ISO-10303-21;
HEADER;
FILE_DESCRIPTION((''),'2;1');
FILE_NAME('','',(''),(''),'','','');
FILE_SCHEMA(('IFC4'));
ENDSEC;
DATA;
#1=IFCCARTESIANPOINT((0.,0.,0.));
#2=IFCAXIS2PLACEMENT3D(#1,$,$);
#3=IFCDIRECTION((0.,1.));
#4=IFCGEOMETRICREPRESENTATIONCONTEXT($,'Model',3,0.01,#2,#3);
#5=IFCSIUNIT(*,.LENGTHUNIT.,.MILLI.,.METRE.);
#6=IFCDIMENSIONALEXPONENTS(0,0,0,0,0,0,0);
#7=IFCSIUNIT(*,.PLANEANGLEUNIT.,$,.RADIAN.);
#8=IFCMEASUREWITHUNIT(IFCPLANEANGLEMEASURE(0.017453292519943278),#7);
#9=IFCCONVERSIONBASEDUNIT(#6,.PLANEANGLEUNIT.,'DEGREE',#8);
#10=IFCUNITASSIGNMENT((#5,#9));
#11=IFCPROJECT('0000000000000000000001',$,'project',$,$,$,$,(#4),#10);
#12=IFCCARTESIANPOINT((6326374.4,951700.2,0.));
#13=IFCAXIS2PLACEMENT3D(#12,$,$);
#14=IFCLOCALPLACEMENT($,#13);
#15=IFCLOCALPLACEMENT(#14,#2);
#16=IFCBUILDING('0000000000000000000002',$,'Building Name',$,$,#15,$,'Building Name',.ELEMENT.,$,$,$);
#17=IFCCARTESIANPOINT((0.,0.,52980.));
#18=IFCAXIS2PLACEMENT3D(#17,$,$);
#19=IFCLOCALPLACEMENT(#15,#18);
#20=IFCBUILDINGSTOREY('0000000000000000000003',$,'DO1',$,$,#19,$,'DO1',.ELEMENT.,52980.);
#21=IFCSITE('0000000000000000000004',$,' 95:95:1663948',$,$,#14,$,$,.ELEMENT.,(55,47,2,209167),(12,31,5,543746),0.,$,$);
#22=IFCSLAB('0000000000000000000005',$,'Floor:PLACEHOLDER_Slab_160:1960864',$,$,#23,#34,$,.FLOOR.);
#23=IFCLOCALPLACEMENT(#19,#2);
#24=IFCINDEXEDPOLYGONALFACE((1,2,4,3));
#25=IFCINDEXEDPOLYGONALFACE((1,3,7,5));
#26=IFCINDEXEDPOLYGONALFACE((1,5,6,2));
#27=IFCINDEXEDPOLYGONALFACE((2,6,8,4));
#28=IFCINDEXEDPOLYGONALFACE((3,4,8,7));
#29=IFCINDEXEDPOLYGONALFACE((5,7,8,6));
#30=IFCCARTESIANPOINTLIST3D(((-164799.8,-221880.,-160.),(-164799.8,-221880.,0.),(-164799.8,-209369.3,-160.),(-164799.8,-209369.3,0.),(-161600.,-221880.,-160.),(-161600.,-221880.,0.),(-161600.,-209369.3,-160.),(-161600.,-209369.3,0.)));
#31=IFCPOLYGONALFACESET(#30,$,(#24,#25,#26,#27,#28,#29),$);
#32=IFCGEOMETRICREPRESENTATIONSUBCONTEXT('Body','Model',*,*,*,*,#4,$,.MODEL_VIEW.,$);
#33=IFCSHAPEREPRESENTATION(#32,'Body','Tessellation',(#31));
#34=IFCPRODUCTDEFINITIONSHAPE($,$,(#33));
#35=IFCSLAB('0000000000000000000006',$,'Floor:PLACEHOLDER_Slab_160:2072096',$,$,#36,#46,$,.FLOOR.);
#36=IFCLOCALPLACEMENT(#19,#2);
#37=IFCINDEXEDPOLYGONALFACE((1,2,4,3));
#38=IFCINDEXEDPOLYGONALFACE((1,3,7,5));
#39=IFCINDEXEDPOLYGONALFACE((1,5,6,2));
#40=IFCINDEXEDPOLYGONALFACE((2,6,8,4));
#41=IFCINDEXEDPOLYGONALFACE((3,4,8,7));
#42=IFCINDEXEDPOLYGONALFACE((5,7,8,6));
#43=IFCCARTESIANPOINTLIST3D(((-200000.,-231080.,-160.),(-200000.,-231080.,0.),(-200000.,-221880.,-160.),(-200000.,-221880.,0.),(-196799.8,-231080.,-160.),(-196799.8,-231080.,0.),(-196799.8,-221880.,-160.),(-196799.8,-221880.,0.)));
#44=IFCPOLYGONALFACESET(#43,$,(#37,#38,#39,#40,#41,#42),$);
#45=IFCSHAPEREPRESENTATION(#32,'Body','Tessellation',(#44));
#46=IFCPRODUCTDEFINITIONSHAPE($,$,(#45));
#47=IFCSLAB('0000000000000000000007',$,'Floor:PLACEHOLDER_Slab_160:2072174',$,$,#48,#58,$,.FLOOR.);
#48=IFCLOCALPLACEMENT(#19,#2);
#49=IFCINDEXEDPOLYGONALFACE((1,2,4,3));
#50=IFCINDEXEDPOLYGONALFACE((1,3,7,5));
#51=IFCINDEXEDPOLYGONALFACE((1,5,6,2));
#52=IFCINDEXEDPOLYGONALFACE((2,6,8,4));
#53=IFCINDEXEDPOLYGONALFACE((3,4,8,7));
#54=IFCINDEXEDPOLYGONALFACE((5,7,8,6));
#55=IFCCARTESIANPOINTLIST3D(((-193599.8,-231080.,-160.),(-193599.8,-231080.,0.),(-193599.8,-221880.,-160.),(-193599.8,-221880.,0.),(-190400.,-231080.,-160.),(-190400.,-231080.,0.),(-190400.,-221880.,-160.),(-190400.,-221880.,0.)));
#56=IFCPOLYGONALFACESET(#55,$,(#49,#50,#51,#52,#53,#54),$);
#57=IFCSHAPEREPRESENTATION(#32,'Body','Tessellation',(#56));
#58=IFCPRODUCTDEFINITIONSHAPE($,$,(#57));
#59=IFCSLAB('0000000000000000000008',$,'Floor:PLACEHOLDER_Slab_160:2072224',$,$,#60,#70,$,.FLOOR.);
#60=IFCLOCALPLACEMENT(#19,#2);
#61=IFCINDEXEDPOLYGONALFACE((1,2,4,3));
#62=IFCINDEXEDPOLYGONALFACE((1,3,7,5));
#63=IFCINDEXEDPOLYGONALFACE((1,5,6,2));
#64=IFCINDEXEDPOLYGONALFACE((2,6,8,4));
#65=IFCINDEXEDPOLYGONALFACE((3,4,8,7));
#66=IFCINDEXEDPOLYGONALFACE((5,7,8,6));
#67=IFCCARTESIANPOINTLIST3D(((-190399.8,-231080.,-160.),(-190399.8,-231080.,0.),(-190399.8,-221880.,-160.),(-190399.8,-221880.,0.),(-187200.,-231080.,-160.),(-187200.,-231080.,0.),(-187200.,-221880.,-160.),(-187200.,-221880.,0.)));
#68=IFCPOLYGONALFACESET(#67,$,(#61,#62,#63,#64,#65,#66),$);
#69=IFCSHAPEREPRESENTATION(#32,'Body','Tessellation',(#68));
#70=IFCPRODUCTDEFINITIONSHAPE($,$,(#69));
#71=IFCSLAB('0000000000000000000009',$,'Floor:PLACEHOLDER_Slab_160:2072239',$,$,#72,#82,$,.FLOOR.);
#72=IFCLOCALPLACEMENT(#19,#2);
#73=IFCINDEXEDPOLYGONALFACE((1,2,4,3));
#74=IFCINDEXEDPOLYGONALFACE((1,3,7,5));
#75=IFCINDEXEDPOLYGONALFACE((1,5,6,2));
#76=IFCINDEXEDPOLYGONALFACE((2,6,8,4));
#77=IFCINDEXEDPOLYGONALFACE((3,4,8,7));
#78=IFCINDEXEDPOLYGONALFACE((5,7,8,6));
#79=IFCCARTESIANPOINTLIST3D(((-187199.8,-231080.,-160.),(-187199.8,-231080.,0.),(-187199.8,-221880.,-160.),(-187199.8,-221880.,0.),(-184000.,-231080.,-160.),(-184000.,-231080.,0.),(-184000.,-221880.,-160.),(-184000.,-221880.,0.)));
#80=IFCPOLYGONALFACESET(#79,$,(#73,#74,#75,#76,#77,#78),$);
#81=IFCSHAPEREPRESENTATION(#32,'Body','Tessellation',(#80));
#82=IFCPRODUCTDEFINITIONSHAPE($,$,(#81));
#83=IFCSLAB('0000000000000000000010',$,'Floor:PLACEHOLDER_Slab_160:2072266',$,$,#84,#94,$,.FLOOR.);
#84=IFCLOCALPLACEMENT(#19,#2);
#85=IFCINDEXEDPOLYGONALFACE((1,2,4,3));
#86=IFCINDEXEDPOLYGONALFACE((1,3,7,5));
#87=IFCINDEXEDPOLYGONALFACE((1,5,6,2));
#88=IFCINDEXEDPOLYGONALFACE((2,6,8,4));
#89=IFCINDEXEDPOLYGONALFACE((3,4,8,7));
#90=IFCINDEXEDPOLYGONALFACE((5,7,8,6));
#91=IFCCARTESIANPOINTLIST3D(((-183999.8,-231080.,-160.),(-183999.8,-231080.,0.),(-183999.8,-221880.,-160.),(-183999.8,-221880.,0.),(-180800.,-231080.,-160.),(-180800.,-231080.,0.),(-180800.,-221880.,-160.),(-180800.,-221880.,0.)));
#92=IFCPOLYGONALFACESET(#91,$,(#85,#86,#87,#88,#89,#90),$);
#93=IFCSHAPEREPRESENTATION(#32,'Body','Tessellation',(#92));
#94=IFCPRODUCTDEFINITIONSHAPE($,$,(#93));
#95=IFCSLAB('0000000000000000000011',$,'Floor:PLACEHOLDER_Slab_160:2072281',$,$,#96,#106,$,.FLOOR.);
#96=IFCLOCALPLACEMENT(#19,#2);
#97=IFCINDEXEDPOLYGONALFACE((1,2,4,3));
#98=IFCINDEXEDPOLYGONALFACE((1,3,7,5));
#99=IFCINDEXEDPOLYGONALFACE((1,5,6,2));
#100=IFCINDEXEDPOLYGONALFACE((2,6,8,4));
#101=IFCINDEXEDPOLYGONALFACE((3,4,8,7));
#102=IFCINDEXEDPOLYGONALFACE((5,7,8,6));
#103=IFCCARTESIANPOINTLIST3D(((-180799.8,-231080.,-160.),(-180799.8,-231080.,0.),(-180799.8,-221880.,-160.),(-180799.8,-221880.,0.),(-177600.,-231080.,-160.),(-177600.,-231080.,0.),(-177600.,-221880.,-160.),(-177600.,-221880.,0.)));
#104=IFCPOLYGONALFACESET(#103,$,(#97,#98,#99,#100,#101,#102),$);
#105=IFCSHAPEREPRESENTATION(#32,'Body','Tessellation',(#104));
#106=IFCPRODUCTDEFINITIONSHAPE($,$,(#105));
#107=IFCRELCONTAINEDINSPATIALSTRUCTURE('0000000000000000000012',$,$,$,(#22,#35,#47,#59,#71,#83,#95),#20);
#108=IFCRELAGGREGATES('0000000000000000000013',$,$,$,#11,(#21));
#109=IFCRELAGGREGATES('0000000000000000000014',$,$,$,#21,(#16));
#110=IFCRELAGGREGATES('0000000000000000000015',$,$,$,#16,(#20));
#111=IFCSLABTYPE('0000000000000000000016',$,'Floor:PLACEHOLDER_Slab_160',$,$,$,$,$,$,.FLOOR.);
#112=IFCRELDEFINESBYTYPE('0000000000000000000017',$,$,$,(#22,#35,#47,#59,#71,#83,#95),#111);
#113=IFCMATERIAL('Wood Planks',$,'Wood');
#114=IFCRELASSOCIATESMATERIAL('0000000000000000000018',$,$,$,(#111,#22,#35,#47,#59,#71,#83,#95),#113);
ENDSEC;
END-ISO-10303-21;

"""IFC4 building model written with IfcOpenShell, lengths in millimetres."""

from ifc_helpers import new_model, entity, si_unit, converted_unit, direction, frame, origin, place, context, subcontext, project, spatial, indexed_curve, outline, extrude, material, type_object, element, save


model = new_model("IFC4")

# Units and contexts
model_context = context("Model", 3, precision=0.01, world=origin(), true_north=direction((0.0, 1.0)))
body_context = subcontext(model_context, "Body", "Model", "MODEL_VIEW")
ifc_project = project(units=[si_unit("LENGTHUNIT", "METRE", prefix="MILLI"), converted_unit("PLANEANGLEUNIT", "DEGREE", entity("IfcPlaneAngleMeasure", 0.017453292519943278), si_unit("PLANEANGLEUNIT", "RADIAN"), dimensions=[0, 0, 0, 0, 0, 0, 0])], contexts=[model_context])

# Site, building, storey
site_placement = place(None, frame((6326374.4, 951700.2, 0.0)))
site = spatial("IfcSite", under=ifc_project, at=site_placement, Name=" 95:95:1663948", CompositionType="ELEMENT", RefLatitude=(55, 47, 2, 209167), RefLongitude=(12, 31, 5, 543746), RefElevation=0.0)
building_placement = place(site_placement, origin())
building = spatial("IfcBuilding", under=site, at=building_placement, Name="Building Name", LongName="Building Name", CompositionType="ELEMENT")
storey_placement = place(building_placement, frame((0.0, 0.0, 52980.0)))
storey = spatial("IfcBuildingStorey", under=building, at=storey_placement, Name="DO1", LongName="DO1", CompositionType="ELEMENT", Elevation=52980.0)

# Slabs
ifc_material_1 = material(Name="Wood Planks", Category="Wood")
slab_type_1 = type_object("IfcSlabType", Name="Floor:PLACEHOLDER_Slab_160", PredefinedType="FLOOR", material=ifc_material_1)
slab_1_placement = place(storey_placement, origin())
element("IfcSlab", 1, at=slab_1_placement, inside=storey, type_object=slab_type_1, material=ifc_material_1, Name="Floor:PLACEHOLDER_Slab_160:1960864", PredefinedType="FLOOR", context=body_context, shape_type="SweptSolid", body=[
    extrude(outline(indexed_curve([(-6255.3, -1599.9), (6255.3, -1599.9), (6255.3, 1599.9), (-6255.3, 1599.9), (-6255.3, -1599.9)], self_intersect=False)), frame((-163199.9, -215624.7, 0.0), z_axis=(0.0, 0.0, -1.0), x_axis=(0.0, 1.0, 0.0)), (0.0, 0.0, 1.0), 160.0),
])
slab_2_placement = place(storey_placement, origin())
element("IfcSlab", 2, at=slab_2_placement, inside=storey, type_object=slab_type_1, material=ifc_material_1, Name="Floor:PLACEHOLDER_Slab_160:2072096", PredefinedType="FLOOR", context=body_context, shape_type="SweptSolid", body=[
    extrude(outline(indexed_curve([(-4600.0, -1600.1), (4600.0, -1600.1), (4600.0, 1600.1), (-4600.0, 1600.1), (-4600.0, -1600.1)], self_intersect=False)), frame((-198399.9, -226480.0, 0.0), z_axis=(0.0, 0.0, -1.0), x_axis=(0.0, 1.0, 0.0)), (0.0, 0.0, 1.0), 160.0),
])
slab_3_placement = place(storey_placement, origin())
element("IfcSlab", 3, at=slab_3_placement, inside=storey, type_object=slab_type_1, material=ifc_material_1, Name="Floor:PLACEHOLDER_Slab_160:2072174", PredefinedType="FLOOR", context=body_context, shape_type="SweptSolid", body=[
    extrude(outline(indexed_curve([(-4600.0, -1599.9), (4600.0, -1599.9), (4600.0, 1599.9), (-4600.0, 1599.9), (-4600.0, -1599.9)], self_intersect=False)), frame((-191999.9, -226480.0, 0.0), z_axis=(0.0, 0.0, -1.0), x_axis=(0.0, 1.0, 0.0)), (0.0, 0.0, 1.0), 160.0),
])
slab_4_placement = place(storey_placement, origin())
element("IfcSlab", 4, at=slab_4_placement, inside=storey, type_object=slab_type_1, material=ifc_material_1, Name="Floor:PLACEHOLDER_Slab_160:2072224", PredefinedType="FLOOR", context=body_context, shape_type="SweptSolid", body=[
    extrude(outline(indexed_curve([(-4600.0, -1599.9), (4600.0, -1599.9), (4600.0, 1599.9), (-4600.0, 1599.9), (-4600.0, -1599.9)], self_intersect=False)), frame((-188799.9, -226480.0, 0.0), z_axis=(0.0, 0.0, -1.0), x_axis=(0.0, 1.0, 0.0)), (0.0, 0.0, 1.0), 160.0),
])
slab_5_placement = place(storey_placement, origin())
element("IfcSlab", 5, at=slab_5_placement, inside=storey, type_object=slab_type_1, material=ifc_material_1, Name="Floor:PLACEHOLDER_Slab_160:2072239", PredefinedType="FLOOR", context=body_context, shape_type="SweptSolid", body=[
    extrude(outline(indexed_curve([(-4600.0, -1599.9), (4600.0, -1599.9), (4600.0, 1599.9), (-4600.0, 1599.9), (-4600.0, -1599.9)], self_intersect=False)), frame((-185599.9, -226480.0, 0.0), z_axis=(0.0, 0.0, -1.0), x_axis=(0.0, 1.0, 0.0)), (0.0, 0.0, 1.0), 160.0),
])
slab_6_placement = place(storey_placement, origin())
element("IfcSlab", 6, at=slab_6_placement, inside=storey, type_object=slab_type_1, material=ifc_material_1, Name="Floor:PLACEHOLDER_Slab_160:2072266", PredefinedType="FLOOR", context=body_context, shape_type="SweptSolid", body=[
    extrude(outline(indexed_curve([(-4600.0, -1599.9), (4600.0, -1599.9), (4600.0, 1599.9), (-4600.0, 1599.9), (-4600.0, -1599.9)], self_intersect=False)), frame((-182399.9, -226480.0, 0.0), z_axis=(0.0, 0.0, -1.0), x_axis=(0.0, 1.0, 0.0)), (0.0, 0.0, 1.0), 160.0),
])
slab_7_placement = place(storey_placement, origin())
element("IfcSlab", 7, at=slab_7_placement, inside=storey, type_object=slab_type_1, material=ifc_material_1, Name="Floor:PLACEHOLDER_Slab_160:2072281", PredefinedType="FLOOR", context=body_context, shape_type="SweptSolid", body=[
    extrude(outline(indexed_curve([(-4600.0, -1599.9), (4600.0, -1599.9), (4600.0, 1599.9), (-4600.0, 1599.9), (-4600.0, -1599.9)], self_intersect=False)), frame((-179199.9, -226480.0, 0.0), z_axis=(0.0, 0.0, -1.0), x_axis=(0.0, 1.0, 0.0)), (0.0, 0.0, 1.0), 160.0),
])

save(model, "model.ifc")
